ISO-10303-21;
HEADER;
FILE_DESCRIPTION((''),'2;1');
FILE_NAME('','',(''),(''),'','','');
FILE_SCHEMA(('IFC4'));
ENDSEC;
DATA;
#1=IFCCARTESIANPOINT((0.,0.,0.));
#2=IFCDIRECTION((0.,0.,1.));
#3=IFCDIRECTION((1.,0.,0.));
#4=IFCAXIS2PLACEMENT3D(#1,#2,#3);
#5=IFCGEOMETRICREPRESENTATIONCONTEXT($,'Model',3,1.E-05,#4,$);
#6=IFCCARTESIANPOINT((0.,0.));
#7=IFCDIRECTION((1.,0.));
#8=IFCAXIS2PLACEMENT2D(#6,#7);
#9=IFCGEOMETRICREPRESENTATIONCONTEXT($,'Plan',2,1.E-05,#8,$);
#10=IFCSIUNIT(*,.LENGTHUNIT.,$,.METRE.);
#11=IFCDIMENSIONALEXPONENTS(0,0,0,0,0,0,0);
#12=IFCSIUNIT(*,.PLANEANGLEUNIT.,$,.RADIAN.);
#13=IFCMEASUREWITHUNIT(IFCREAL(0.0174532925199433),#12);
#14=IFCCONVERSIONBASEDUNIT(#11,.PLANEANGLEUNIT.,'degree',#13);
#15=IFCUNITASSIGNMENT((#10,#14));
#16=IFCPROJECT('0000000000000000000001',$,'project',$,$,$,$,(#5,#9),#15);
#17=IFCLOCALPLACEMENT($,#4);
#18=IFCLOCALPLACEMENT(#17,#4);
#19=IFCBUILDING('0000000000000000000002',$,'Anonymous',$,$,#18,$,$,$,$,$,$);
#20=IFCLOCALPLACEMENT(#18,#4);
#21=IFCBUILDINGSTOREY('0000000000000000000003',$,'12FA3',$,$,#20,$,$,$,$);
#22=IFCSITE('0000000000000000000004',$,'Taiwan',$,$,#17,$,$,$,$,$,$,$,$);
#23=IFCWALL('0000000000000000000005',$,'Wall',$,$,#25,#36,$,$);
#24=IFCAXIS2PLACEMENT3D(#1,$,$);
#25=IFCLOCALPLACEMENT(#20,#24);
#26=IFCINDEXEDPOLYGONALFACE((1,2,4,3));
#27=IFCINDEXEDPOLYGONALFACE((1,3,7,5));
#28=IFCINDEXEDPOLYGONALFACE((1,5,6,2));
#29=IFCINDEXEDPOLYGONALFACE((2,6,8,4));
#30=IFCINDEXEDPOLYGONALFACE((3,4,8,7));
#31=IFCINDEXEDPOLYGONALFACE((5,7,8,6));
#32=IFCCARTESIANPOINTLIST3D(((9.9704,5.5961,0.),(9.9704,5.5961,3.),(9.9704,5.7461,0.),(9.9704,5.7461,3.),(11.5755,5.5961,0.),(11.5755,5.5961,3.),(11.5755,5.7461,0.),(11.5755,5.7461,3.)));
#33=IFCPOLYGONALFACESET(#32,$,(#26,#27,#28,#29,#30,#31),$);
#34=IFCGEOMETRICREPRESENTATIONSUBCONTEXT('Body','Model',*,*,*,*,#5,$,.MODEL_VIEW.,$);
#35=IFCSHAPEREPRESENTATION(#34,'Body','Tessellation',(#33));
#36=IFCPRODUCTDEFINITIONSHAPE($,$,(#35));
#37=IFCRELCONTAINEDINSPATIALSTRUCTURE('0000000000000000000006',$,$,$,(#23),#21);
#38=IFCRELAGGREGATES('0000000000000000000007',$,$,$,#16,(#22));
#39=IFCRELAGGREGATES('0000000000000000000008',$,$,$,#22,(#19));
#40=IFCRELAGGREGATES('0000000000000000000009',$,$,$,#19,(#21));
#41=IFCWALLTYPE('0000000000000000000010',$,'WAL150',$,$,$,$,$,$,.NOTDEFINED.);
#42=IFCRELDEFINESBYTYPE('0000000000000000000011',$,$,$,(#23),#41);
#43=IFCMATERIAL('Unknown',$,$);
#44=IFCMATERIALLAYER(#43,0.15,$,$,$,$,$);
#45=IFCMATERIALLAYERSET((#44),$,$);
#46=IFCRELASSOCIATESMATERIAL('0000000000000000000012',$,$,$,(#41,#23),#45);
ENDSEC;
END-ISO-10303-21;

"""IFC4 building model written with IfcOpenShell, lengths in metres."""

from ifc_helpers import new_model, entity, si_unit, converted_unit, frame, origin_with_axes, origin_2d_with_axis, place, context, subcontext, project, spatial, line, indexed_curve, outline, extrude, material, layer, layer_set, layer_usage, type_object, element, save


model = new_model("IFC4")

# Units and contexts
model_context = context("Model", 3, precision=1e-05, world=origin_with_axes())
plan_context = context("Plan", 2, precision=1e-05, world=origin_2d_with_axis())
body_context_1 = subcontext(model_context, "Body", "Model", "MODEL_VIEW")
ifc_project = project(units=[si_unit("LENGTHUNIT", "METRE"), converted_unit("PLANEANGLEUNIT", "degree", entity("IfcReal", 0.0174532925199433), si_unit("PLANEANGLEUNIT", "RADIAN"), dimensions=[0, 0, 0, 0, 0, 0, 0])], contexts=[model_context, plan_context])

# Site, building, storey
site_placement = place(None, origin_with_axes())
site = spatial("IfcSite", under=ifc_project, at=site_placement, Name="Taiwan")
building_placement = place(site_placement, origin_with_axes())
building = spatial("IfcBuilding", under=site, at=building_placement, Name="Anonymous")
storey_placement = place(building_placement, origin_with_axes())
storey = spatial("IfcBuildingStorey", under=building, at=storey_placement, Name="12FA3")

# Shared definitions
ifc_material = material(Name="Unknown")

# Shared definitions
ifc_layer_1 = layer(ifc_material, 0.15)
ifc_layer_set_1 = layer_set([ifc_layer_1])
wall_type_1 = type_object("IfcWallType", Name="WAL150", PredefinedType="NOTDEFINED", material=ifc_layer_set_1)

# Wall
ifc_layer_usage_1 = layer_usage(ifc_layer_set_1, "AXIS2", "POSITIVE", 0.0)
wall_1_placement = place(storey_placement, frame((9.9704, 5.5961, 0.0), z_axis=(0.0, 0.0, 1.0), x_axis=(1.0, 0.0, 0.0)))
element("IfcWall", 1, at=wall_1_placement, inside=storey, type_object=wall_type_1, material=ifc_layer_usage_1, Name="Wall", context=body_context_1, shape_type="SweptSolid", body=[
    extrude(outline(indexed_curve([(0.0, 0.0), (0.0, 0.15), (1.6051, 0.15), (1.6051, 0.0)], segments=[line(1, 2, 3, 4, 1)])), origin_with_axes(), (0.0, 0.0, 1.0), 3.0),
])

save(model, "model.ifc")
